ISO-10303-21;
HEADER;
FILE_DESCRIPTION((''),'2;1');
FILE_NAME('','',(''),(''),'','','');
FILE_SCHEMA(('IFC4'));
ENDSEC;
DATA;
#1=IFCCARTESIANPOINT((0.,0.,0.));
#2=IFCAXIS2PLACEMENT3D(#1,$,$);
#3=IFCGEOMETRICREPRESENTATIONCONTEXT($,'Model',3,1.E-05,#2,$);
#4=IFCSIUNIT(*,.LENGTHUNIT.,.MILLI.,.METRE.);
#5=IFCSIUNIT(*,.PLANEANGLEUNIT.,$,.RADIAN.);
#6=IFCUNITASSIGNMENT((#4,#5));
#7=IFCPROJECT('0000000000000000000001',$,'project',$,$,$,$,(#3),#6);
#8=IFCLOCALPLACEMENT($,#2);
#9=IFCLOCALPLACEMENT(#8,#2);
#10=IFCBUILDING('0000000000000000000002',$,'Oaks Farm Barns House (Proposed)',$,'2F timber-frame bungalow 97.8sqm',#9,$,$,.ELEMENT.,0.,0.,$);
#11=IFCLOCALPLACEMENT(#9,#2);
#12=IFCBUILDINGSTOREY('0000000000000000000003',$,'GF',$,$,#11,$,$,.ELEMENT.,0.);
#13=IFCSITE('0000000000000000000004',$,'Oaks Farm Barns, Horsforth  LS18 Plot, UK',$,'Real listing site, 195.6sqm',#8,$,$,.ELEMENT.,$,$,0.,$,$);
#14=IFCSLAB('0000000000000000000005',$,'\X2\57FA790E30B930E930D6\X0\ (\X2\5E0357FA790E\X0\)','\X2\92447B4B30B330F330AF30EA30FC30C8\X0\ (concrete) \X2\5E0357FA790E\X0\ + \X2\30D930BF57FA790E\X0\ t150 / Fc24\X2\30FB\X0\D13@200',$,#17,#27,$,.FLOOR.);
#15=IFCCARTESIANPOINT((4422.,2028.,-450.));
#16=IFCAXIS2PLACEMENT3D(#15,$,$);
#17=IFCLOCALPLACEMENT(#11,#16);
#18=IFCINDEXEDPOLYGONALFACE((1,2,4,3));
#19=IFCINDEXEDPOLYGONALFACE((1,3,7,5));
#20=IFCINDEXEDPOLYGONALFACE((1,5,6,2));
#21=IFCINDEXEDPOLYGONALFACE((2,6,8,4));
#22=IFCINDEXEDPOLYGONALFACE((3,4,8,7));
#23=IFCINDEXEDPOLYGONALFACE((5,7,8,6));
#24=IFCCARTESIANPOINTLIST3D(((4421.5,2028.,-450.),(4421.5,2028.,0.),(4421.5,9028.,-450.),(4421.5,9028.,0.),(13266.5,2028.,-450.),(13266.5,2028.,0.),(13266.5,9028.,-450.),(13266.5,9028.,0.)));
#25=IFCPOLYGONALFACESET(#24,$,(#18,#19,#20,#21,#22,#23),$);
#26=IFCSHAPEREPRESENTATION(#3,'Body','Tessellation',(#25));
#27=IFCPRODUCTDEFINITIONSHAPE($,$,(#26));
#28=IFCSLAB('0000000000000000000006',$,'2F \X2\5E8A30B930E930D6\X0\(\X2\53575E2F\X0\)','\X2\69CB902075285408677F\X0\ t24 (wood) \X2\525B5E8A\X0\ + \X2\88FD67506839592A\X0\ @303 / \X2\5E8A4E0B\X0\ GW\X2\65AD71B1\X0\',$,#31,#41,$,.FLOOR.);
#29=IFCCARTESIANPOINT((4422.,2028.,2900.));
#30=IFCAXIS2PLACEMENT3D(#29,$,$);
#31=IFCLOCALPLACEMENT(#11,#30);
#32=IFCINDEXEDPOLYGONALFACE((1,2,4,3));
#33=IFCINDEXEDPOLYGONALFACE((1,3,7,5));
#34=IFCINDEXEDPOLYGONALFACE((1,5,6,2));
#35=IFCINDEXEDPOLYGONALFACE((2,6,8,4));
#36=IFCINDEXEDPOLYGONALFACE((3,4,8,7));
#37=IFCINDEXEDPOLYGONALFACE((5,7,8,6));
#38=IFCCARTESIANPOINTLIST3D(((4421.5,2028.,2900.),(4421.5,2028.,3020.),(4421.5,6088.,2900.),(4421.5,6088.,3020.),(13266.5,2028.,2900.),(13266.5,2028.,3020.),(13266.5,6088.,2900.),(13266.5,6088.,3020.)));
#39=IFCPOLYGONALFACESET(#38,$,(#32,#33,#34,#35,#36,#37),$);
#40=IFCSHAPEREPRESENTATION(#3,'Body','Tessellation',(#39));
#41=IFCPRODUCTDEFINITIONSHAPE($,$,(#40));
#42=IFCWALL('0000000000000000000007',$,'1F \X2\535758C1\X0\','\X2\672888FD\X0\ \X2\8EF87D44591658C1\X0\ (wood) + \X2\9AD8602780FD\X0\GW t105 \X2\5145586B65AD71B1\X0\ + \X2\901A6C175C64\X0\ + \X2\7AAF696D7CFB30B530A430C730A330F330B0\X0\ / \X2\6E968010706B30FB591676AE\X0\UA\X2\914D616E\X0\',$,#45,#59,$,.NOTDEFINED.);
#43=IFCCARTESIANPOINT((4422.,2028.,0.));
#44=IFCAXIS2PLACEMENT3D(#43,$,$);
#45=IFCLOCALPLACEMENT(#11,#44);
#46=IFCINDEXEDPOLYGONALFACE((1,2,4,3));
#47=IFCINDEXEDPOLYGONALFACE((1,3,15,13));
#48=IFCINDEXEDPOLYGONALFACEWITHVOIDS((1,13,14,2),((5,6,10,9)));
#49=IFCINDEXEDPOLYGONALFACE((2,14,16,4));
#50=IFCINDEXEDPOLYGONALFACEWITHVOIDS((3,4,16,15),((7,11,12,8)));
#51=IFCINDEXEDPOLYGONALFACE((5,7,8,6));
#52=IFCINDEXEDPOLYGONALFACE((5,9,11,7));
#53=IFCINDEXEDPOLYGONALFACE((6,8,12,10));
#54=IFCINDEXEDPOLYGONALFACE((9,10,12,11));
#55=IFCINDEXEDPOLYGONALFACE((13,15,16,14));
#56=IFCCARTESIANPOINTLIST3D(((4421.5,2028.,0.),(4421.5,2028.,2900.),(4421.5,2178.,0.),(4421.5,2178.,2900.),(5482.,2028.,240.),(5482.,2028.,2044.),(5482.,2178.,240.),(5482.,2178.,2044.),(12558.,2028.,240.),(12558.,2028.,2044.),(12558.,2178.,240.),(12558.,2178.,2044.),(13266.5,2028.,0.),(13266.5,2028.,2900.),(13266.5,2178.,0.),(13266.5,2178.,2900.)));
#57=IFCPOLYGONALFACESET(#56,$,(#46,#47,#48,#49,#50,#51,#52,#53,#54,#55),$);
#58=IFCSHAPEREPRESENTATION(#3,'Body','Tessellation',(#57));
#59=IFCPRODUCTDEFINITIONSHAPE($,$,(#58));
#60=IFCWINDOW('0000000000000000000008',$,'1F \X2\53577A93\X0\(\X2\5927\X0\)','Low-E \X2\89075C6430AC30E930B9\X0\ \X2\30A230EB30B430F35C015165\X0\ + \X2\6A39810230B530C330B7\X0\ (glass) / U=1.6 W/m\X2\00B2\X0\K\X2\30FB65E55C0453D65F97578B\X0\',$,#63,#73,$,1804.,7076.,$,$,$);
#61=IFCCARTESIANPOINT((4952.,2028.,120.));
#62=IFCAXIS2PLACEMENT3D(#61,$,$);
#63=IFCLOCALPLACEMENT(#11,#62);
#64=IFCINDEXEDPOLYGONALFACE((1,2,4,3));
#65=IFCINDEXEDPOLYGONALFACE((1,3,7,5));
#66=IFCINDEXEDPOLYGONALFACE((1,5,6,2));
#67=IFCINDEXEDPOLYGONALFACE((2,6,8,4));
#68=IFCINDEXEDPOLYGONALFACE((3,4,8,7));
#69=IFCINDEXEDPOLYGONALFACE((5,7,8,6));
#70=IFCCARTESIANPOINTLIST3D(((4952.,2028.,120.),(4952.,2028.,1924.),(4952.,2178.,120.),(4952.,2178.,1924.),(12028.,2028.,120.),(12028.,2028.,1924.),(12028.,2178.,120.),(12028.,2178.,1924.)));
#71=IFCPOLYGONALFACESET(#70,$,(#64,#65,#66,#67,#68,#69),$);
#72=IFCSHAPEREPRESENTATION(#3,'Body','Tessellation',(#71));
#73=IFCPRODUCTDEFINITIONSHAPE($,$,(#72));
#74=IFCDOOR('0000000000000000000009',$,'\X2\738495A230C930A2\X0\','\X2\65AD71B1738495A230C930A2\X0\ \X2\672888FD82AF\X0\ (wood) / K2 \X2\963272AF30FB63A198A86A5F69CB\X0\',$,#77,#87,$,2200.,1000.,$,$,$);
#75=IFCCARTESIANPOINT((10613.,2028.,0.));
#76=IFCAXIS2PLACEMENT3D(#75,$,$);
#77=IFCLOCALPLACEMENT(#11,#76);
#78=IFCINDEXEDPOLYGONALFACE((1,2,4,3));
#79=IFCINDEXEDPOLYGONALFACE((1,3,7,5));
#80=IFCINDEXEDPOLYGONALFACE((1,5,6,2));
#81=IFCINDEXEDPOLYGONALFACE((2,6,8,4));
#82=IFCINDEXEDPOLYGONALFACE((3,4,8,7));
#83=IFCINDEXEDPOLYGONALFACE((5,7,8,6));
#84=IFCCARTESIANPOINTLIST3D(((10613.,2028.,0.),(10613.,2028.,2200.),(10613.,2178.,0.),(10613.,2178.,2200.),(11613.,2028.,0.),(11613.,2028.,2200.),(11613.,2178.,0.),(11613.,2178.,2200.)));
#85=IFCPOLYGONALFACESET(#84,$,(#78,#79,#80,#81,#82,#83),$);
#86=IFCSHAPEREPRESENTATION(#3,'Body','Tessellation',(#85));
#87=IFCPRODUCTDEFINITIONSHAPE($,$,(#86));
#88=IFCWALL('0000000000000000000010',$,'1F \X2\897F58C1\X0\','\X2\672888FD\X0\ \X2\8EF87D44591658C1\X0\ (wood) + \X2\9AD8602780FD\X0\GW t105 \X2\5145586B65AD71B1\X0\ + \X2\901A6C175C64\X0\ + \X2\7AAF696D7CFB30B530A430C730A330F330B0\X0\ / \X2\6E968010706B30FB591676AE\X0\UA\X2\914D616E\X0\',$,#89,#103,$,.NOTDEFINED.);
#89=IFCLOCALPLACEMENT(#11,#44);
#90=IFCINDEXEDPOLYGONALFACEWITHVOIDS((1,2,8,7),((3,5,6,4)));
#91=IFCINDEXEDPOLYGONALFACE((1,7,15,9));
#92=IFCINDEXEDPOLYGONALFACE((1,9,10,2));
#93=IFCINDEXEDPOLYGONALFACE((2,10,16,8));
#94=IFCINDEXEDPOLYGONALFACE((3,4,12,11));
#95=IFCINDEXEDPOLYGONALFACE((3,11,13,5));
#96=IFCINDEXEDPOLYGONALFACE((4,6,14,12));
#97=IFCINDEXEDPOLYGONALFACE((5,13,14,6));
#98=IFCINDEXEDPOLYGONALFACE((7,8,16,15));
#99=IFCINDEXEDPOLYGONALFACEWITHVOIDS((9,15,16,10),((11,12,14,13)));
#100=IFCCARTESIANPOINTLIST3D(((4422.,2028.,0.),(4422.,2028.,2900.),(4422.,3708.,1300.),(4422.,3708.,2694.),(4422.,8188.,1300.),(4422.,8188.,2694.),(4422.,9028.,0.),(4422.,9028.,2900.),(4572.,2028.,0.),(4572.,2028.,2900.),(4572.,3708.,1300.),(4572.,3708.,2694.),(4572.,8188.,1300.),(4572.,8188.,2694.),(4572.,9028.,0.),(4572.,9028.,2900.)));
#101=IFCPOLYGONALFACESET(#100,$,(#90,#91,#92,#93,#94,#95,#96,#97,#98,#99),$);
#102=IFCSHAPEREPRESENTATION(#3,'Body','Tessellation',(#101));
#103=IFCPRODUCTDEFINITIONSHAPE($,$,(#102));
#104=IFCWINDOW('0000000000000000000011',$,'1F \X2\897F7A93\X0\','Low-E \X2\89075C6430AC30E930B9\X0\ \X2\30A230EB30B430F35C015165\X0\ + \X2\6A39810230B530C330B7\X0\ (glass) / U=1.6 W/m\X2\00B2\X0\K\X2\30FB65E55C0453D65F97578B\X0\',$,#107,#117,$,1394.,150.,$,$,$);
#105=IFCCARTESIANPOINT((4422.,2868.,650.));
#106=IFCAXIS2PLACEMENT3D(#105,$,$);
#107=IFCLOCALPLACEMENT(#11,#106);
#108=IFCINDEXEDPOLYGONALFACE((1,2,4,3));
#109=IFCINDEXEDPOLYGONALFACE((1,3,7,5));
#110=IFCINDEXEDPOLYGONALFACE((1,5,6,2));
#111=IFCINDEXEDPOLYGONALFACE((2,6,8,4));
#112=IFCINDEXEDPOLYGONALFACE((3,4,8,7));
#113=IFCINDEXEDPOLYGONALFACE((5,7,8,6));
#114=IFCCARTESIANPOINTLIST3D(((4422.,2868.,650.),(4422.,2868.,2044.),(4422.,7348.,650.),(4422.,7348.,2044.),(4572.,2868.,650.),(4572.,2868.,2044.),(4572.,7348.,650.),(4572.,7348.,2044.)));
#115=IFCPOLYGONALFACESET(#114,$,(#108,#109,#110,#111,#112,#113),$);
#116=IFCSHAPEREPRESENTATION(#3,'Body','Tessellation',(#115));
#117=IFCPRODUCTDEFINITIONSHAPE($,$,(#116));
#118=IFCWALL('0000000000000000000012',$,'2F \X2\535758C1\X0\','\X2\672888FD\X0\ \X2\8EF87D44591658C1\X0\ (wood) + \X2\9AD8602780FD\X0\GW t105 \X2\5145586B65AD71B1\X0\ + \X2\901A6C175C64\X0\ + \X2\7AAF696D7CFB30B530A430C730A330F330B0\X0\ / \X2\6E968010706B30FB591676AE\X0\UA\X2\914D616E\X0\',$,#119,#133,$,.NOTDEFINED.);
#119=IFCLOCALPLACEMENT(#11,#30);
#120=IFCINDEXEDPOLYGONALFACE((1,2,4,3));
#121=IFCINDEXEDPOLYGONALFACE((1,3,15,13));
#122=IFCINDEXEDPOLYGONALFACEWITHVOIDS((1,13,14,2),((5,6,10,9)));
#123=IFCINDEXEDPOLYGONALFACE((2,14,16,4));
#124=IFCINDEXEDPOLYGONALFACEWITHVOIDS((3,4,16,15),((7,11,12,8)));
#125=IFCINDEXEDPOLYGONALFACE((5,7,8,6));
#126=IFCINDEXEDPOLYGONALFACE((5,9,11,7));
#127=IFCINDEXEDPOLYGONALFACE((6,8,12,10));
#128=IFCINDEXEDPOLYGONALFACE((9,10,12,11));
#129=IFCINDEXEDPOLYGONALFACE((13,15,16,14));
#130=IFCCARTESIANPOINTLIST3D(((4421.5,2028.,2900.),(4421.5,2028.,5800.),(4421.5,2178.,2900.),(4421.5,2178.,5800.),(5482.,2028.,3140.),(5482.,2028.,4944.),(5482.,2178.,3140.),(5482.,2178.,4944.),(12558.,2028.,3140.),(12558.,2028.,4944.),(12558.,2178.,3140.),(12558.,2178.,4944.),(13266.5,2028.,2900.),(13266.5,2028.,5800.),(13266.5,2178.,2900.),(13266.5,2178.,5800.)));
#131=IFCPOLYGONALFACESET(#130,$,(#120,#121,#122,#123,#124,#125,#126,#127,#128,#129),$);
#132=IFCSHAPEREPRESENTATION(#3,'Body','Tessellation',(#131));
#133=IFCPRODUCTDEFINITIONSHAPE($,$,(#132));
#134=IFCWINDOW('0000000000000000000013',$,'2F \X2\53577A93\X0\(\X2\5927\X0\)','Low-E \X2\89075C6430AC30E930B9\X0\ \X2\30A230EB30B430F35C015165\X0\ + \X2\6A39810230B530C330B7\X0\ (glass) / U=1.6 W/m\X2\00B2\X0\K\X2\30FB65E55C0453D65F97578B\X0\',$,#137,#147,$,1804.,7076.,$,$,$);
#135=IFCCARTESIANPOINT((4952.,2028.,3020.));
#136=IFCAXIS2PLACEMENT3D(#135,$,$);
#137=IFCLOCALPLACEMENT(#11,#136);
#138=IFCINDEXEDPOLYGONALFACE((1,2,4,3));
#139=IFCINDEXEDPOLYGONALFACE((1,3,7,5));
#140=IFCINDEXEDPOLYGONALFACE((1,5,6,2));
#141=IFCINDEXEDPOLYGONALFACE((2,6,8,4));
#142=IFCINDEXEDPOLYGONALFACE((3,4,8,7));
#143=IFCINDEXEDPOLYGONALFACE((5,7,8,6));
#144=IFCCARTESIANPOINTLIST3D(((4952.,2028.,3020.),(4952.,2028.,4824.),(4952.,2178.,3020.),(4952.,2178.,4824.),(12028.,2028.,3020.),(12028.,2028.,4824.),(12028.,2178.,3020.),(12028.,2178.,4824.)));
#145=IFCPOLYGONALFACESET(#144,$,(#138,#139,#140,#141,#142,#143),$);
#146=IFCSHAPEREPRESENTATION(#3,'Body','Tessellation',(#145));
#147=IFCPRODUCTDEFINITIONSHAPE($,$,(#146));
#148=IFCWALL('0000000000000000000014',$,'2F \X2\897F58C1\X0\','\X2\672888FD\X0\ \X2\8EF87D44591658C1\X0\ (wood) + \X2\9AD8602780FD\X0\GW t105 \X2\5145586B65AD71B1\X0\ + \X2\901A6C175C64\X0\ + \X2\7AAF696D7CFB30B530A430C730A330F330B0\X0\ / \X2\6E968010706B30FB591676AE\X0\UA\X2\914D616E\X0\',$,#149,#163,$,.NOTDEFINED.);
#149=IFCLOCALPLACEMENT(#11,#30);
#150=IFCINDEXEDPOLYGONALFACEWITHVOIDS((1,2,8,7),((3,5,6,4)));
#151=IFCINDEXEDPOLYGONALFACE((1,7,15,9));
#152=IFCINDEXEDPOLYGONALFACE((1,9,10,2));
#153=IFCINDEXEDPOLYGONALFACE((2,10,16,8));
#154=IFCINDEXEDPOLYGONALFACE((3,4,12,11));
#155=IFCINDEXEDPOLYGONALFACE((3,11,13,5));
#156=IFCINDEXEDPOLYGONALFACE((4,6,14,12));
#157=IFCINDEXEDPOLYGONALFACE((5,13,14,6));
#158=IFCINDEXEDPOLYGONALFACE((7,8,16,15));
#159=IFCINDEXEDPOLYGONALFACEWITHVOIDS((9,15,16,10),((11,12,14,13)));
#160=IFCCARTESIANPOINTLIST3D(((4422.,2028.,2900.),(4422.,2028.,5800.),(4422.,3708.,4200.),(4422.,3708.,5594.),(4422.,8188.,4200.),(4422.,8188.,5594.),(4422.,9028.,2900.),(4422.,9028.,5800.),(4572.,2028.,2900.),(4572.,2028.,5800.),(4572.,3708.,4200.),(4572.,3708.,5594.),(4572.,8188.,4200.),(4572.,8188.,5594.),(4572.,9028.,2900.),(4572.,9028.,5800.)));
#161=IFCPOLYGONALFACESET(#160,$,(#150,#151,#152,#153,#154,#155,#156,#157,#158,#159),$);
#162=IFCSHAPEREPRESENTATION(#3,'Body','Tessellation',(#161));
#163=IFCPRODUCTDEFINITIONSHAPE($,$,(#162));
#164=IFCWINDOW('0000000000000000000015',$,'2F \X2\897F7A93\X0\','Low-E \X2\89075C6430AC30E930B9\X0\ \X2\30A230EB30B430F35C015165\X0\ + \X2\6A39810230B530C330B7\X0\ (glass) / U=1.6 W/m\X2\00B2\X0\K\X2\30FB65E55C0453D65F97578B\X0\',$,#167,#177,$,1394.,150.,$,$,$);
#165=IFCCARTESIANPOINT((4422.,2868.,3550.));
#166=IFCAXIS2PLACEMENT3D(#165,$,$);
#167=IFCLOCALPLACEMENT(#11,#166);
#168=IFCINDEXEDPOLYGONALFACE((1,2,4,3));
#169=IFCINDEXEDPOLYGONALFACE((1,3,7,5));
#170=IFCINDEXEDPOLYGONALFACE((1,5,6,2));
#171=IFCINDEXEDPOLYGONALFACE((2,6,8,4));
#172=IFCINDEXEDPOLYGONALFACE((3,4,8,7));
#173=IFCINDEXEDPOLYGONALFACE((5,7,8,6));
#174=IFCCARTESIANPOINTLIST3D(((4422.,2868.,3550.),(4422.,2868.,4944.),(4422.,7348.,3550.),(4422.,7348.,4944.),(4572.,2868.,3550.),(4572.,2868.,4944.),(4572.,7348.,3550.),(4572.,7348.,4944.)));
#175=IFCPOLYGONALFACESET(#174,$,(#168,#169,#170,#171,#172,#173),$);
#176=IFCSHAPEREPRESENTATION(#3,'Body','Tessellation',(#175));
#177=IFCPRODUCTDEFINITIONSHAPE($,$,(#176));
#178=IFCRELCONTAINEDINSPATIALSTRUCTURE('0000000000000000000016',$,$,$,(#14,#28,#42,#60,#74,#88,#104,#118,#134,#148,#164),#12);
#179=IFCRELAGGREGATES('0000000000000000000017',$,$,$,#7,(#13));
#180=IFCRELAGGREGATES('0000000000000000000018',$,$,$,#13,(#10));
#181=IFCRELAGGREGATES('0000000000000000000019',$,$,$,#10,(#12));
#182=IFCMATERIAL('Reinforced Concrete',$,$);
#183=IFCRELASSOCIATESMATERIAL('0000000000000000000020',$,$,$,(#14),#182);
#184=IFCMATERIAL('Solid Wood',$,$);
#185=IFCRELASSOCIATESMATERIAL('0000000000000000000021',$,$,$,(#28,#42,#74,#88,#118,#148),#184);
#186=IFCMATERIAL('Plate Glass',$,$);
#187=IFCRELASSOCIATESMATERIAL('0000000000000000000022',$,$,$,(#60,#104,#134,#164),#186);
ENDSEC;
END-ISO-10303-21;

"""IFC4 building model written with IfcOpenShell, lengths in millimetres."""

from ifc_helpers import new_model, si_unit, frame, frame_2d, origin, place, context, project, spatial, rectangle, extrude, material, element, fill, save


model = new_model("IFC4")

# Units and contexts
model_context = context("Model", 3, precision=1e-05, world=origin())
ifc_project = project(units=[si_unit("LENGTHUNIT", "METRE", prefix="MILLI"), si_unit("PLANEANGLEUNIT", "RADIAN")], contexts=[model_context])

# Site, building, storey
site_placement = place(None, origin())
site = spatial("IfcSite", under=ifc_project, at=site_placement, Name="Oaks Farm Barns, Horsforth  LS18 Plot, UK", ObjectType="Real listing site, 195.6sqm", CompositionType="ELEMENT", RefElevation=0.0)
building_placement = place(site_placement, origin())
building = spatial("IfcBuilding", under=site, at=building_placement, Name="Oaks Farm Barns House (Proposed)", ObjectType="2F timber-frame bungalow 97.8sqm", CompositionType="ELEMENT", ElevationOfRefHeight=0.0, ElevationOfTerrain=0.0)
storey_placement = place(building_placement, origin())
storey = spatial("IfcBuildingStorey", under=building, at=storey_placement, Name="GF", CompositionType="ELEMENT", Elevation=0.0)

# Slabs
ifc_material_1 = material(Name="Reinforced Concrete")
slab_1_placement = place(storey_placement, frame((4422.0, 2028.0, -450.0)))
element("IfcSlab", 1, at=slab_1_placement, inside=storey, material=ifc_material_1, Name="基礎スラブ (布基礎)", Description="鉄筋コンクリート (concrete) 布基礎 + ベタ基礎 t150 / Fc24・D13@200", PredefinedType="FLOOR", context=model_context, shape_type="SweptSolid", body=[
    extrude(rectangle(XDim=8845.0, YDim=7000.0, at=frame_2d((4422.0, 3500.0))), frame((4422.0, 2028.0, -450.0)), (0.0, 0.0, 1.0), 450.0),
])
ifc_material_2 = material(Name="Solid Wood")
slab_2_placement = place(storey_placement, frame((4422.0, 2028.0, 2900.0)))
element("IfcSlab", 2, at=slab_2_placement, inside=storey, material=ifc_material_2, Name="2F 床スラブ(南帯)", Description="構造用合板 t24 (wood) 剛床 + 製材根太 @303 / 床下 GW断熱", PredefinedType="FLOOR", context=model_context, shape_type="SweptSolid", body=[
    extrude(rectangle(XDim=8845.0, YDim=4060.0, at=frame_2d((4422.0, 2030.0))), frame((4422.0, 2028.0, 2900.0)), (0.0, 0.0, 1.0), 120.0),
])

# Wall, openings, window, door
wall_1_placement = place(storey_placement, frame((4422.0, 2028.0, 0.0)))
wall_1 = element("IfcWall", 3, at=wall_1_placement, inside=storey, material=ifc_material_2, Name="1F 南壁", Description="木製 軸組外壁 (wood) + 高性能GW t105 充填断熱 + 通気層 + 窯業系サイディング / 準耐火・外皮UA配慮", PredefinedType="NOTDEFINED", context=model_context, shape_type="SweptSolid", body=[
    extrude(rectangle(XDim=8845.0, YDim=150.0, at=frame_2d((4422.0, 75.0))), frame((4422.0, 2028.0, 0.0)), (0.0, 0.0, 1.0), 2900.0),
])
opening_1_placement = place(storey_placement, frame((4952.0, 2028.0, 120.0)))
opening_1 = element("IfcOpeningElement", 4, at=opening_1_placement, cuts=wall_1, PredefinedType="NOTDEFINED", context=model_context, shape_type="SweptSolid", body=[
    extrude(rectangle(XDim=7076.0, YDim=150.0, at=frame_2d((3538.0, 75.0))), frame((4952.0, 2028.0, 120.0)), (0.0, 0.0, 1.0), 1804.0),
])
opening_2_placement = place(storey_placement, frame((10613.0, 2028.0, 0.0)))
opening_2 = element("IfcOpeningElement", 5, at=opening_2_placement, cuts=wall_1, PredefinedType="NOTDEFINED", context=model_context, shape_type="SweptSolid", body=[
    extrude(rectangle(XDim=1000.0, YDim=150.0, at=frame_2d((500.0, 75.0))), frame((10613.0, 2028.0, 0.0)), (0.0, 0.0, 1.0), 2200.0),
])
ifc_material_3 = material(Name="Plate Glass")
window_1_placement = place(storey_placement, frame((4952.0, 2028.0, 120.0)))
window_1 = element("IfcWindow", 6, at=window_1_placement, inside=storey, material=ifc_material_3, Name="1F 南窓(大)", Description="Low-E 複層ガラス アルゴン封入 + 樹脂サッシ (glass) / U=1.6 W/m²K・日射取得型", OverallHeight=1804.0, OverallWidth=7076.0, context=model_context, shape_type="SweptSolid", body=[
    extrude(rectangle(XDim=7076.0, YDim=150.0, at=frame_2d((3538.0, 75.0))), frame((4952.0, 2028.0, 120.0)), (0.0, 0.0, 1.0), 1804.0),
])
fill(opening_1, window_1)
door_placement = place(storey_placement, frame((10613.0, 2028.0, 0.0)))
door = element("IfcDoor", 7, at=door_placement, inside=storey, material=ifc_material_2, Name="玄関ドア", Description="断熱玄関ドア 木製芯 (wood) / K2 防犯・採風機構", OverallHeight=2200.0, OverallWidth=1000.0, context=model_context, shape_type="SweptSolid", body=[
    extrude(rectangle(XDim=1000.0, YDim=150.0, at=frame_2d((500.0, 75.0))), frame((10613.0, 2028.0, 0.0)), (0.0, 0.0, 1.0), 2200.0),
])
fill(opening_2, door)

# Wall, opening, window
wall_2_placement = place(storey_placement, frame((4422.0, 2028.0, 0.0)))
wall_2 = element("IfcWall", 8, at=wall_2_placement, inside=storey, material=ifc_material_2, Name="1F 西壁", Description="木製 軸組外壁 (wood) + 高性能GW t105 充填断熱 + 通気層 + 窯業系サイディング / 準耐火・外皮UA配慮", PredefinedType="NOTDEFINED", context=model_context, shape_type="SweptSolid", body=[
    extrude(rectangle(XDim=150.0, YDim=7000.0, at=frame_2d((75.0, 3500.0))), frame((4422.0, 2028.0, 0.0)), (0.0, 0.0, 1.0), 2900.0),
])
opening_3_placement = place(storey_placement, frame((4422.0, 2868.0, 650.0)))
opening_3 = element("IfcOpeningElement", 9, at=opening_3_placement, cuts=wall_2, PredefinedType="NOTDEFINED", context=model_context, shape_type="SweptSolid", body=[
    extrude(rectangle(XDim=150.0, YDim=4480.0, at=frame_2d((75.0, 2240.0))), frame((4422.0, 2868.0, 650.0)), (0.0, 0.0, 1.0), 1394.0),
])
window_2_placement = place(storey_placement, frame((4422.0, 2868.0, 650.0)))
window_2 = element("IfcWindow", 10, at=window_2_placement, inside=storey, material=ifc_material_3, Name="1F 西窓", Description="Low-E 複層ガラス アルゴン封入 + 樹脂サッシ (glass) / U=1.6 W/m²K・日射取得型", OverallHeight=1394.0, OverallWidth=150.0, context=model_context, shape_type="SweptSolid", body=[
    extrude(rectangle(XDim=150.0, YDim=4480.0, at=frame_2d((75.0, 2240.0))), frame((4422.0, 2868.0, 650.0)), (0.0, 0.0, 1.0), 1394.0),
])
fill(opening_3, window_2)

# Walls, openings, windows
wall_3_placement = place(storey_placement, frame((4422.0, 2028.0, 2900.0)))
wall_3 = element("IfcWall", 11, at=wall_3_placement, inside=storey, material=ifc_material_2, Name="2F 南壁", Description="木製 軸組外壁 (wood) + 高性能GW t105 充填断熱 + 通気層 + 窯業系サイディング / 準耐火・外皮UA配慮", PredefinedType="NOTDEFINED", context=model_context, shape_type="SweptSolid", body=[
    extrude(rectangle(XDim=8845.0, YDim=150.0, at=frame_2d((4422.0, 75.0))), frame((4422.0, 2028.0, 2900.0)), (0.0, 0.0, 1.0), 2900.0),
])
opening_4_placement = place(storey_placement, frame((4952.0, 2028.0, 3020.0)))
opening_4 = element("IfcOpeningElement", 12, at=opening_4_placement, cuts=wall_3, PredefinedType="NOTDEFINED", context=model_context, shape_type="SweptSolid", body=[
    extrude(rectangle(XDim=7076.0, YDim=150.0, at=frame_2d((3538.0, 75.0))), frame((4952.0, 2028.0, 3020.0)), (0.0, 0.0, 1.0), 1804.0),
])
window_3_placement = place(storey_placement, frame((4952.0, 2028.0, 3020.0)))
window_3 = element("IfcWindow", 13, at=window_3_placement, inside=storey, material=ifc_material_3, Name="2F 南窓(大)", Description="Low-E 複層ガラス アルゴン封入 + 樹脂サッシ (glass) / U=1.6 W/m²K・日射取得型", OverallHeight=1804.0, OverallWidth=7076.0, context=model_context, shape_type="SweptSolid", body=[
    extrude(rectangle(XDim=7076.0, YDim=150.0, at=frame_2d((3538.0, 75.0))), frame((4952.0, 2028.0, 3020.0)), (0.0, 0.0, 1.0), 1804.0),
])
fill(opening_4, window_3)
wall_4_placement = place(storey_placement, frame((4422.0, 2028.0, 2900.0)))
wall_4 = element("IfcWall", 14, at=wall_4_placement, inside=storey, material=ifc_material_2, Name="2F 西壁", Description="木製 軸組外壁 (wood) + 高性能GW t105 充填断熱 + 通気層 + 窯業系サイディング / 準耐火・外皮UA配慮", PredefinedType="NOTDEFINED", context=model_context, shape_type="SweptSolid", body=[
    extrude(rectangle(XDim=150.0, YDim=7000.0, at=frame_2d((75.0, 3500.0))), frame((4422.0, 2028.0, 2900.0)), (0.0, 0.0, 1.0), 2900.0),
])
opening_5_placement = place(storey_placement, frame((4422.0, 2868.0, 3550.0)))
opening_5 = element("IfcOpeningElement", 15, at=opening_5_placement, cuts=wall_4, PredefinedType="NOTDEFINED", context=model_context, shape_type="SweptSolid", body=[
    extrude(rectangle(XDim=150.0, YDim=4480.0, at=frame_2d((75.0, 2240.0))), frame((4422.0, 2868.0, 3550.0)), (0.0, 0.0, 1.0), 1394.0),
])
window_4_placement = place(storey_placement, frame((4422.0, 2868.0, 3550.0)))
window_4 = element("IfcWindow", 16, at=window_4_placement, inside=storey, material=ifc_material_3, Name="2F 西窓", Description="Low-E 複層ガラス アルゴン封入 + 樹脂サッシ (glass) / U=1.6 W/m²K・日射取得型", OverallHeight=1394.0, OverallWidth=150.0, context=model_context, shape_type="SweptSolid", body=[
    extrude(rectangle(XDim=150.0, YDim=4480.0, at=frame_2d((75.0, 2240.0))), frame((4422.0, 2868.0, 3550.0)), (0.0, 0.0, 1.0), 1394.0),
])
fill(opening_5, window_4)

save(model, "model.ifc")
